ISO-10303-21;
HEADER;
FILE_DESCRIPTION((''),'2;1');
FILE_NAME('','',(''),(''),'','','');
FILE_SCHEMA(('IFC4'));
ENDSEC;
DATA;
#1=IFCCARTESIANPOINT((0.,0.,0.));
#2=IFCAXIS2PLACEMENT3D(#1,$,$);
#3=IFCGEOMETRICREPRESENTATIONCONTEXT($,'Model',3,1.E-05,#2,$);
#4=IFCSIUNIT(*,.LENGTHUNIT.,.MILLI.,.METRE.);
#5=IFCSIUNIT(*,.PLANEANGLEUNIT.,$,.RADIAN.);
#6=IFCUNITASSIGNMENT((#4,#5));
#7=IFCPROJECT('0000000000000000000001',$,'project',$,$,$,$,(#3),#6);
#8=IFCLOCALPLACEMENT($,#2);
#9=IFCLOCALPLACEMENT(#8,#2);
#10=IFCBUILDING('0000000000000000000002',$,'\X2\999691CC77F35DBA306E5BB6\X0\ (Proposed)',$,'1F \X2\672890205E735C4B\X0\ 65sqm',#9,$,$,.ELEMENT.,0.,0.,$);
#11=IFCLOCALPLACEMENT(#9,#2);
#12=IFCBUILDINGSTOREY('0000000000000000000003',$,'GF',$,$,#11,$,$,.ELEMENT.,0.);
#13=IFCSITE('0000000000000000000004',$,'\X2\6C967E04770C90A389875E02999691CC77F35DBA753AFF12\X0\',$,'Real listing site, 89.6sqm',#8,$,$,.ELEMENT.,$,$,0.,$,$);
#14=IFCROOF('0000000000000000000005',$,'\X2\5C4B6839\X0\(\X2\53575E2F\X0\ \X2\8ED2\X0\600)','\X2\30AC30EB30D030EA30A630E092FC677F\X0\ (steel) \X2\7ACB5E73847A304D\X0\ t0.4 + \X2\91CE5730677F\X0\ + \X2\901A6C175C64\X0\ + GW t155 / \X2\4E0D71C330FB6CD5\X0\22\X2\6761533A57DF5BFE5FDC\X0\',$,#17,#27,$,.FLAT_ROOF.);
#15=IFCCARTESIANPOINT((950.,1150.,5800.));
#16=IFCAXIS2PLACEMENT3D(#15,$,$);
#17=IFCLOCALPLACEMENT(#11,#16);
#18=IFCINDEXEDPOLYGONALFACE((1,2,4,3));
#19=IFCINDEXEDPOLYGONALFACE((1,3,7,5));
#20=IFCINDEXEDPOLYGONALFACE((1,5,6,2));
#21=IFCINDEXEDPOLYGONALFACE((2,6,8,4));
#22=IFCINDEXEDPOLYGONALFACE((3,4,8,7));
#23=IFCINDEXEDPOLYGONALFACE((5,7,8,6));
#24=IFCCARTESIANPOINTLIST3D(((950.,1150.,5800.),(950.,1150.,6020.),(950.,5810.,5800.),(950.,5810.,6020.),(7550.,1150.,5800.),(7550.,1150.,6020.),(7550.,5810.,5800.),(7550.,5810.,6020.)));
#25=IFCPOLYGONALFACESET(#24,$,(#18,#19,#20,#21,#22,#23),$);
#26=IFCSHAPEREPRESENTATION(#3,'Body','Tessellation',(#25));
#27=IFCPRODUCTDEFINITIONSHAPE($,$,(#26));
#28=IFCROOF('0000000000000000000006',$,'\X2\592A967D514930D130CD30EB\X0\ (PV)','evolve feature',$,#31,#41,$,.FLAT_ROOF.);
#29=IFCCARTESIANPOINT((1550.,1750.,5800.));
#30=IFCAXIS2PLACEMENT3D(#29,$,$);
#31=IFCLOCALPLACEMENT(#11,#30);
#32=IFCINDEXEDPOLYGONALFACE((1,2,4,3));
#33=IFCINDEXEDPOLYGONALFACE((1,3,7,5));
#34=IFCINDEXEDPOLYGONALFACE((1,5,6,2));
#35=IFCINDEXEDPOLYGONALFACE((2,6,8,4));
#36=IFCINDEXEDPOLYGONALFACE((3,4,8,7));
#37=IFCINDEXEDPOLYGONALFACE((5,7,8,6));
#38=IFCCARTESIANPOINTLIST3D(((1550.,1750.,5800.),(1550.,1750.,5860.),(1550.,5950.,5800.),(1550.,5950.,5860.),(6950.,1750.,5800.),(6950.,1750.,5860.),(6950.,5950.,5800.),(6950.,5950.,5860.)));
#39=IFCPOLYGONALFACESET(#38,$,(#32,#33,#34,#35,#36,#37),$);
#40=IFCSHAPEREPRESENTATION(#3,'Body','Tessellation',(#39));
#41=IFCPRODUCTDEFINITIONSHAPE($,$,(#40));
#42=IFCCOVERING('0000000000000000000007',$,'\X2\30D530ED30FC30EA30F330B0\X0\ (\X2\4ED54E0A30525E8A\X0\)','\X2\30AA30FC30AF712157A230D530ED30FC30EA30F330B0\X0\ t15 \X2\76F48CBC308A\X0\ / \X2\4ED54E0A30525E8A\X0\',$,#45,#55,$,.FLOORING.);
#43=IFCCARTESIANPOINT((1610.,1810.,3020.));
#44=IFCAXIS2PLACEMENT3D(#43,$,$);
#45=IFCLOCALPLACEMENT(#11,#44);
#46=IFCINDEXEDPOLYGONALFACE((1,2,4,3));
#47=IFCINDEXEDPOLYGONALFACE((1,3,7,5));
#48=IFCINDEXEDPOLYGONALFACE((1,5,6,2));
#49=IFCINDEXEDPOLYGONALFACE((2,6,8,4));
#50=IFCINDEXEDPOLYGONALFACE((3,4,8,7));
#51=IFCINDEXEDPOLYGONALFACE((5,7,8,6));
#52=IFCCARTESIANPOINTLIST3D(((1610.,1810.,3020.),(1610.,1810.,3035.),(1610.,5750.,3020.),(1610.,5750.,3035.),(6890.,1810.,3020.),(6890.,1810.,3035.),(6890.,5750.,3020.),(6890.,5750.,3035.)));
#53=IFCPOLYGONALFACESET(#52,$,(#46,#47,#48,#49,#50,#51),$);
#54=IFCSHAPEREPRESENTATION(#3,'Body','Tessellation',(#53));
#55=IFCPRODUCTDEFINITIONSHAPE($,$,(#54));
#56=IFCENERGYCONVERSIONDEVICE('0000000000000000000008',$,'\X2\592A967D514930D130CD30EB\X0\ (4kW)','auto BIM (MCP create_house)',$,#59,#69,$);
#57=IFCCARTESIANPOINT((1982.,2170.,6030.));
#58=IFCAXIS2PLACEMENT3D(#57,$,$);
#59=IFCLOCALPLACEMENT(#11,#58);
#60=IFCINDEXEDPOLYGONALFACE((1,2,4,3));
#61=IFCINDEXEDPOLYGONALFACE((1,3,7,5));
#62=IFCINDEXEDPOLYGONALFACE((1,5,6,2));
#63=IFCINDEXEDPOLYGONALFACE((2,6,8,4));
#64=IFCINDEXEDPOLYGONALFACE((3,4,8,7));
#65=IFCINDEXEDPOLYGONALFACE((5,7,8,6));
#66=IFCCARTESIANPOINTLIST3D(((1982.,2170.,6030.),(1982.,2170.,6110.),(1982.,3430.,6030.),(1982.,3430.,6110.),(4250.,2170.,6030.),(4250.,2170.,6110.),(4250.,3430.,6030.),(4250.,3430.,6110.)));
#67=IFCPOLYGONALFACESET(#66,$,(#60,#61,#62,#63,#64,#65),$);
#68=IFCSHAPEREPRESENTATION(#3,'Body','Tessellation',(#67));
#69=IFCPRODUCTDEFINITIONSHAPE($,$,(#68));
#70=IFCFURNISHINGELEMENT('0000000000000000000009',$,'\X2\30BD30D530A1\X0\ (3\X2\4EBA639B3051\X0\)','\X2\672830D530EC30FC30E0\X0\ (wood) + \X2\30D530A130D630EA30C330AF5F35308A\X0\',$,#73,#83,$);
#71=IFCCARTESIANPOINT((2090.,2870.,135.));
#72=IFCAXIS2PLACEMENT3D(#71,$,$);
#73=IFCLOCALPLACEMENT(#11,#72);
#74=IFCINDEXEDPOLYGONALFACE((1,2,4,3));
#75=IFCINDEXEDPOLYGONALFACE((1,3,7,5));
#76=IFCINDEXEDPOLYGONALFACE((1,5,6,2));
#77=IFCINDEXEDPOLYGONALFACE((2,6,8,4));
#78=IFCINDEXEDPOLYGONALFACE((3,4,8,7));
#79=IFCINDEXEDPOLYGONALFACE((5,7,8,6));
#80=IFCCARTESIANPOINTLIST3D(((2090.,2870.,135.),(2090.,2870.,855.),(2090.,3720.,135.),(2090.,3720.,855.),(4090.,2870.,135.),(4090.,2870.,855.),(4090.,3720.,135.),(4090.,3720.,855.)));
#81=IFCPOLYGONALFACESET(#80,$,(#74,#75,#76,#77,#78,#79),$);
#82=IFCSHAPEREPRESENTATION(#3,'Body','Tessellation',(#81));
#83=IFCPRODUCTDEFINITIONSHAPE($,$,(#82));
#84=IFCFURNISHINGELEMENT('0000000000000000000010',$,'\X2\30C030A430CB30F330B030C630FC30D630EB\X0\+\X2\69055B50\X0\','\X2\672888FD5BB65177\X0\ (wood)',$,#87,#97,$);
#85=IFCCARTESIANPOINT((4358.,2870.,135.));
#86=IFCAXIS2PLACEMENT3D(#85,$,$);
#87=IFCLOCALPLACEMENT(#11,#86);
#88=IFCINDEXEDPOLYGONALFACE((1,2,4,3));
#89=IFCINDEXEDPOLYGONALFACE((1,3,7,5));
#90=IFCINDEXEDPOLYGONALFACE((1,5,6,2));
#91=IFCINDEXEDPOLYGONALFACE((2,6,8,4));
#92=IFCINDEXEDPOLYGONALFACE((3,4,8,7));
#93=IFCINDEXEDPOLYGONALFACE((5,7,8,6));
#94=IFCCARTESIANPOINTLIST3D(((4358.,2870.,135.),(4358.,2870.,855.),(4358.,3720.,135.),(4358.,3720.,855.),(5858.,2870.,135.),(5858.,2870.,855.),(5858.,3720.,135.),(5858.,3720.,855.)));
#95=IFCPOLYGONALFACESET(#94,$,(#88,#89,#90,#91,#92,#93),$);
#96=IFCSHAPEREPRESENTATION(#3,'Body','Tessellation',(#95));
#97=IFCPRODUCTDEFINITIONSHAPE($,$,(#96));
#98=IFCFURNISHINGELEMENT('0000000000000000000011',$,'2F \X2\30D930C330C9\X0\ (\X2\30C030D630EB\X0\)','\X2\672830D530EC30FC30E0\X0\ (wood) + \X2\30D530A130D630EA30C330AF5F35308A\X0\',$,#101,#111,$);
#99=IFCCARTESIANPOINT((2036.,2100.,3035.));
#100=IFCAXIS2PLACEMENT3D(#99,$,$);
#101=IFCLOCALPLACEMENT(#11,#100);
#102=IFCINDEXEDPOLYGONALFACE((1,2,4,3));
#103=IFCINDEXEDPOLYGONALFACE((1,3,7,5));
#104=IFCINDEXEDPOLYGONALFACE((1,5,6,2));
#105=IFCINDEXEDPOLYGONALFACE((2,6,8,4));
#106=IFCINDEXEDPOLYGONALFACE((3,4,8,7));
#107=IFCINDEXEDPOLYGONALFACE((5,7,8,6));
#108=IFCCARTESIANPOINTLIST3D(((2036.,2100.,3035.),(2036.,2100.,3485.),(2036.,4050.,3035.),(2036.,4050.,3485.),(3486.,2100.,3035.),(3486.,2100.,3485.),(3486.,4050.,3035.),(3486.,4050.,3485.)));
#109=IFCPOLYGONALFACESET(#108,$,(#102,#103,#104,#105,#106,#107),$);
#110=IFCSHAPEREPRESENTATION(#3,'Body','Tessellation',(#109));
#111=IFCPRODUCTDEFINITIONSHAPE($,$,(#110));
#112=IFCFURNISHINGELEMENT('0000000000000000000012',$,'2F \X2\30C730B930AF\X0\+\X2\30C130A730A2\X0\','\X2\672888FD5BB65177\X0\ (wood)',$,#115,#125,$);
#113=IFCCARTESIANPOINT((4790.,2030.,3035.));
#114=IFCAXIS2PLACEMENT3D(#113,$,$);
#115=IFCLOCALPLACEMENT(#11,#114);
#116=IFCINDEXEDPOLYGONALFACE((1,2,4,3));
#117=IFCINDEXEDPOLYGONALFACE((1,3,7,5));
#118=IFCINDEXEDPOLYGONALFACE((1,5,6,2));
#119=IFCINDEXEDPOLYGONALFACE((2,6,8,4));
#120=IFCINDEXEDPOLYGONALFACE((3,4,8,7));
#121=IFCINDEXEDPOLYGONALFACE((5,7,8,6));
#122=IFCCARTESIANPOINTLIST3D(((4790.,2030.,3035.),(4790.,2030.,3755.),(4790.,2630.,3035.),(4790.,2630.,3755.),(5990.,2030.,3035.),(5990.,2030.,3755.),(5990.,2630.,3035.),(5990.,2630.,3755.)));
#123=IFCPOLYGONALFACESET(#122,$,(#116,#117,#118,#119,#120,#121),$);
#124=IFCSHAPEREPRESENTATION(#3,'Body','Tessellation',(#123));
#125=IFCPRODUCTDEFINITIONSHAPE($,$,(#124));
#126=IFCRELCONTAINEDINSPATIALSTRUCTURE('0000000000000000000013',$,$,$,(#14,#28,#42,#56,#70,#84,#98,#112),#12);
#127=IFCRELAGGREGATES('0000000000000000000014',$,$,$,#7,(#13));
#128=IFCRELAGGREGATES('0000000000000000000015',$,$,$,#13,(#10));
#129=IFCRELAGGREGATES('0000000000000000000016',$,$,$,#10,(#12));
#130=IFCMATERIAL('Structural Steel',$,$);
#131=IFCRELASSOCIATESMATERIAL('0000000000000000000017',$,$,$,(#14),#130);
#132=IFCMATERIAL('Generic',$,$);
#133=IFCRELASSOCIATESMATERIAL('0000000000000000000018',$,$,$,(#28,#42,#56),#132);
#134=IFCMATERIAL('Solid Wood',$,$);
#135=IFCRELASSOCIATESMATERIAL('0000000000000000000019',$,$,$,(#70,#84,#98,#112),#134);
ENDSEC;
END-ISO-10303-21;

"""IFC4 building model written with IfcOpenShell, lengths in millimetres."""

from ifc_helpers import new_model, si_unit, frame, frame_2d, origin, place, context, project, spatial, rectangle, extrude, material, element, save


model = new_model("IFC4")

# Units and contexts
model_context = context("Model", 3, precision=1e-05, world=origin())
ifc_project = project(units=[si_unit("LENGTHUNIT", "METRE", prefix="MILLI"), si_unit("PLANEANGLEUNIT", "RADIAN")], contexts=[model_context])

# Site, building, storey
site_placement = place(None, origin())
site = spatial("IfcSite", under=ifc_project, at=site_placement, Name="沖縄県那覇市首里石嶺町２", ObjectType="Real listing site, 89.6sqm", CompositionType="ELEMENT", RefElevation=0.0)
building_placement = place(site_placement, origin())
building = spatial("IfcBuilding", under=site, at=building_placement, Name="首里石嶺の家 (Proposed)", ObjectType="1F 木造平屋 65sqm", CompositionType="ELEMENT", ElevationOfRefHeight=0.0, ElevationOfTerrain=0.0)
storey_placement = place(building_placement, origin())
storey = spatial("IfcBuildingStorey", under=building, at=storey_placement, Name="GF", CompositionType="ELEMENT", Elevation=0.0)

# Shared definitions
ifc_material_1 = material(Name="Solid Wood")

# Shared definitions
ifc_material_2 = material(Name="Generic")

# Roofs
ifc_material_3 = material(Name="Structural Steel")
for number, where, name in (
    (1, (950.0, 1150.0, 5800.0), "屋根(南帯 軒600)"),
):
    element("IfcRoof", number, at=place(storey_placement, frame(where)), inside=storey, material=ifc_material_3, Name=name, Description="ガルバリウム鋼板 (steel) 立平葺き t0.4 + 野地板 + 通気層 + GW t155 / 不燃・法22条区域対応", PredefinedType="FLAT_ROOF", context=model_context, shape_type="SweptSolid", body=[
        extrude(rectangle(XDim=6600.0, YDim=4660.0, at=frame_2d((3300.0, 2330.0))), frame((950.0, 1150.0, 5800.0)), (0.0, 0.0, 1.0), 220.0),
    ])
roof_placement = place(storey_placement, frame((1550.0, 1750.0, 5800.0)))
element("IfcRoof", 2, at=roof_placement, inside=storey, material=ifc_material_2, Name="太陽光パネル (PV)", Description="evolve feature", PredefinedType="FLAT_ROOF", context=model_context, shape_type="SweptSolid", body=[
    extrude(rectangle(XDim=5400.0, YDim=4200.0, at=frame_2d((2700.0, 2100.0))), frame((1550.0, 1750.0, 5800.0)), (0.0, 0.0, 1.0), 60.0),
])

# Covering
covering_placement = place(storey_placement, frame((1610.0, 1810.0, 3020.0)))
element("IfcCovering", 3, at=covering_placement, inside=storey, material=ifc_material_2, Name="フローリング (仕上げ床)", Description="オーク無垢フローリング t15 直貼り / 仕上げ床", PredefinedType="FLOORING", context=model_context, shape_type="SweptSolid", body=[
    extrude(rectangle(XDim=5280.0, YDim=3940.0, at=frame_2d((2640.0, 1970.0))), frame((1610.0, 1810.0, 3020.0)), (0.0, 0.0, 1.0), 15.0),
])

# Energy conversion device
energy_conversion_device_placement = place(storey_placement, frame((1982.0, 2170.0, 6030.0)))
element("IfcEnergyConversionDevice", 4, at=energy_conversion_device_placement, inside=storey, material=ifc_material_2, Name="太陽光パネル (4kW)", Description="auto BIM (MCP create_house)", context=model_context, shape_type="SweptSolid", body=[
    extrude(rectangle(XDim=2268.0, YDim=1260.0, at=frame_2d((1134.0, 630.0))), frame((1982.0, 2170.0, 6030.0)), (0.0, 0.0, 1.0), 80.0),
])

# Furnishing elements
furnishing_1_placement = place(storey_placement, frame((2090.0, 2870.0, 135.0)))
element("IfcFurnishingElement", 5, at=furnishing_1_placement, inside=storey, material=ifc_material_1, Name="ソファ (3人掛け)", Description="木フレーム (wood) + ファブリック張り", context=model_context, shape_type="SweptSolid", body=[
    extrude(rectangle(XDim=2000.0, YDim=850.0, at=frame_2d((1000.0, 425.0))), frame((2090.0, 2870.0, 135.0)), (0.0, 0.0, 1.0), 720.0),
])
furnishing_2_placement = place(storey_placement, frame((4358.0, 2870.0, 135.0)))
element("IfcFurnishingElement", 6, at=furnishing_2_placement, inside=storey, material=ifc_material_1, Name="ダイニングテーブル+椅子", Description="木製家具 (wood)", context=model_context, shape_type="SweptSolid", body=[
    extrude(rectangle(XDim=1500.0, YDim=850.0, at=frame_2d((750.0, 425.0))), frame((4358.0, 2870.0, 135.0)), (0.0, 0.0, 1.0), 720.0),
])
furnishing_3_placement = place(storey_placement, frame((2036.0, 2100.0, 3035.0)))
element("IfcFurnishingElement", 7, at=furnishing_3_placement, inside=storey, material=ifc_material_1, Name="2F ベッド (ダブル)", Description="木フレーム (wood) + ファブリック張り", context=model_context, shape_type="SweptSolid", body=[
    extrude(rectangle(XDim=1450.0, YDim=1950.0, at=frame_2d((725.0, 975.0))), frame((2036.0, 2100.0, 3035.0)), (0.0, 0.0, 1.0), 450.0),
])
furnishing_4_placement = place(storey_placement, frame((4790.0, 2030.0, 3035.0)))
element("IfcFurnishingElement", 8, at=furnishing_4_placement, inside=storey, material=ifc_material_1, Name="2F デスク+チェア", Description="木製家具 (wood)", context=model_context, shape_type="SweptSolid", body=[
    extrude(rectangle(XDim=1200.0, YDim=600.0, at=frame_2d((600.0, 300.0))), frame((4790.0, 2030.0, 3035.0)), (0.0, 0.0, 1.0), 720.0),
])

save(model, "model.ifc")
